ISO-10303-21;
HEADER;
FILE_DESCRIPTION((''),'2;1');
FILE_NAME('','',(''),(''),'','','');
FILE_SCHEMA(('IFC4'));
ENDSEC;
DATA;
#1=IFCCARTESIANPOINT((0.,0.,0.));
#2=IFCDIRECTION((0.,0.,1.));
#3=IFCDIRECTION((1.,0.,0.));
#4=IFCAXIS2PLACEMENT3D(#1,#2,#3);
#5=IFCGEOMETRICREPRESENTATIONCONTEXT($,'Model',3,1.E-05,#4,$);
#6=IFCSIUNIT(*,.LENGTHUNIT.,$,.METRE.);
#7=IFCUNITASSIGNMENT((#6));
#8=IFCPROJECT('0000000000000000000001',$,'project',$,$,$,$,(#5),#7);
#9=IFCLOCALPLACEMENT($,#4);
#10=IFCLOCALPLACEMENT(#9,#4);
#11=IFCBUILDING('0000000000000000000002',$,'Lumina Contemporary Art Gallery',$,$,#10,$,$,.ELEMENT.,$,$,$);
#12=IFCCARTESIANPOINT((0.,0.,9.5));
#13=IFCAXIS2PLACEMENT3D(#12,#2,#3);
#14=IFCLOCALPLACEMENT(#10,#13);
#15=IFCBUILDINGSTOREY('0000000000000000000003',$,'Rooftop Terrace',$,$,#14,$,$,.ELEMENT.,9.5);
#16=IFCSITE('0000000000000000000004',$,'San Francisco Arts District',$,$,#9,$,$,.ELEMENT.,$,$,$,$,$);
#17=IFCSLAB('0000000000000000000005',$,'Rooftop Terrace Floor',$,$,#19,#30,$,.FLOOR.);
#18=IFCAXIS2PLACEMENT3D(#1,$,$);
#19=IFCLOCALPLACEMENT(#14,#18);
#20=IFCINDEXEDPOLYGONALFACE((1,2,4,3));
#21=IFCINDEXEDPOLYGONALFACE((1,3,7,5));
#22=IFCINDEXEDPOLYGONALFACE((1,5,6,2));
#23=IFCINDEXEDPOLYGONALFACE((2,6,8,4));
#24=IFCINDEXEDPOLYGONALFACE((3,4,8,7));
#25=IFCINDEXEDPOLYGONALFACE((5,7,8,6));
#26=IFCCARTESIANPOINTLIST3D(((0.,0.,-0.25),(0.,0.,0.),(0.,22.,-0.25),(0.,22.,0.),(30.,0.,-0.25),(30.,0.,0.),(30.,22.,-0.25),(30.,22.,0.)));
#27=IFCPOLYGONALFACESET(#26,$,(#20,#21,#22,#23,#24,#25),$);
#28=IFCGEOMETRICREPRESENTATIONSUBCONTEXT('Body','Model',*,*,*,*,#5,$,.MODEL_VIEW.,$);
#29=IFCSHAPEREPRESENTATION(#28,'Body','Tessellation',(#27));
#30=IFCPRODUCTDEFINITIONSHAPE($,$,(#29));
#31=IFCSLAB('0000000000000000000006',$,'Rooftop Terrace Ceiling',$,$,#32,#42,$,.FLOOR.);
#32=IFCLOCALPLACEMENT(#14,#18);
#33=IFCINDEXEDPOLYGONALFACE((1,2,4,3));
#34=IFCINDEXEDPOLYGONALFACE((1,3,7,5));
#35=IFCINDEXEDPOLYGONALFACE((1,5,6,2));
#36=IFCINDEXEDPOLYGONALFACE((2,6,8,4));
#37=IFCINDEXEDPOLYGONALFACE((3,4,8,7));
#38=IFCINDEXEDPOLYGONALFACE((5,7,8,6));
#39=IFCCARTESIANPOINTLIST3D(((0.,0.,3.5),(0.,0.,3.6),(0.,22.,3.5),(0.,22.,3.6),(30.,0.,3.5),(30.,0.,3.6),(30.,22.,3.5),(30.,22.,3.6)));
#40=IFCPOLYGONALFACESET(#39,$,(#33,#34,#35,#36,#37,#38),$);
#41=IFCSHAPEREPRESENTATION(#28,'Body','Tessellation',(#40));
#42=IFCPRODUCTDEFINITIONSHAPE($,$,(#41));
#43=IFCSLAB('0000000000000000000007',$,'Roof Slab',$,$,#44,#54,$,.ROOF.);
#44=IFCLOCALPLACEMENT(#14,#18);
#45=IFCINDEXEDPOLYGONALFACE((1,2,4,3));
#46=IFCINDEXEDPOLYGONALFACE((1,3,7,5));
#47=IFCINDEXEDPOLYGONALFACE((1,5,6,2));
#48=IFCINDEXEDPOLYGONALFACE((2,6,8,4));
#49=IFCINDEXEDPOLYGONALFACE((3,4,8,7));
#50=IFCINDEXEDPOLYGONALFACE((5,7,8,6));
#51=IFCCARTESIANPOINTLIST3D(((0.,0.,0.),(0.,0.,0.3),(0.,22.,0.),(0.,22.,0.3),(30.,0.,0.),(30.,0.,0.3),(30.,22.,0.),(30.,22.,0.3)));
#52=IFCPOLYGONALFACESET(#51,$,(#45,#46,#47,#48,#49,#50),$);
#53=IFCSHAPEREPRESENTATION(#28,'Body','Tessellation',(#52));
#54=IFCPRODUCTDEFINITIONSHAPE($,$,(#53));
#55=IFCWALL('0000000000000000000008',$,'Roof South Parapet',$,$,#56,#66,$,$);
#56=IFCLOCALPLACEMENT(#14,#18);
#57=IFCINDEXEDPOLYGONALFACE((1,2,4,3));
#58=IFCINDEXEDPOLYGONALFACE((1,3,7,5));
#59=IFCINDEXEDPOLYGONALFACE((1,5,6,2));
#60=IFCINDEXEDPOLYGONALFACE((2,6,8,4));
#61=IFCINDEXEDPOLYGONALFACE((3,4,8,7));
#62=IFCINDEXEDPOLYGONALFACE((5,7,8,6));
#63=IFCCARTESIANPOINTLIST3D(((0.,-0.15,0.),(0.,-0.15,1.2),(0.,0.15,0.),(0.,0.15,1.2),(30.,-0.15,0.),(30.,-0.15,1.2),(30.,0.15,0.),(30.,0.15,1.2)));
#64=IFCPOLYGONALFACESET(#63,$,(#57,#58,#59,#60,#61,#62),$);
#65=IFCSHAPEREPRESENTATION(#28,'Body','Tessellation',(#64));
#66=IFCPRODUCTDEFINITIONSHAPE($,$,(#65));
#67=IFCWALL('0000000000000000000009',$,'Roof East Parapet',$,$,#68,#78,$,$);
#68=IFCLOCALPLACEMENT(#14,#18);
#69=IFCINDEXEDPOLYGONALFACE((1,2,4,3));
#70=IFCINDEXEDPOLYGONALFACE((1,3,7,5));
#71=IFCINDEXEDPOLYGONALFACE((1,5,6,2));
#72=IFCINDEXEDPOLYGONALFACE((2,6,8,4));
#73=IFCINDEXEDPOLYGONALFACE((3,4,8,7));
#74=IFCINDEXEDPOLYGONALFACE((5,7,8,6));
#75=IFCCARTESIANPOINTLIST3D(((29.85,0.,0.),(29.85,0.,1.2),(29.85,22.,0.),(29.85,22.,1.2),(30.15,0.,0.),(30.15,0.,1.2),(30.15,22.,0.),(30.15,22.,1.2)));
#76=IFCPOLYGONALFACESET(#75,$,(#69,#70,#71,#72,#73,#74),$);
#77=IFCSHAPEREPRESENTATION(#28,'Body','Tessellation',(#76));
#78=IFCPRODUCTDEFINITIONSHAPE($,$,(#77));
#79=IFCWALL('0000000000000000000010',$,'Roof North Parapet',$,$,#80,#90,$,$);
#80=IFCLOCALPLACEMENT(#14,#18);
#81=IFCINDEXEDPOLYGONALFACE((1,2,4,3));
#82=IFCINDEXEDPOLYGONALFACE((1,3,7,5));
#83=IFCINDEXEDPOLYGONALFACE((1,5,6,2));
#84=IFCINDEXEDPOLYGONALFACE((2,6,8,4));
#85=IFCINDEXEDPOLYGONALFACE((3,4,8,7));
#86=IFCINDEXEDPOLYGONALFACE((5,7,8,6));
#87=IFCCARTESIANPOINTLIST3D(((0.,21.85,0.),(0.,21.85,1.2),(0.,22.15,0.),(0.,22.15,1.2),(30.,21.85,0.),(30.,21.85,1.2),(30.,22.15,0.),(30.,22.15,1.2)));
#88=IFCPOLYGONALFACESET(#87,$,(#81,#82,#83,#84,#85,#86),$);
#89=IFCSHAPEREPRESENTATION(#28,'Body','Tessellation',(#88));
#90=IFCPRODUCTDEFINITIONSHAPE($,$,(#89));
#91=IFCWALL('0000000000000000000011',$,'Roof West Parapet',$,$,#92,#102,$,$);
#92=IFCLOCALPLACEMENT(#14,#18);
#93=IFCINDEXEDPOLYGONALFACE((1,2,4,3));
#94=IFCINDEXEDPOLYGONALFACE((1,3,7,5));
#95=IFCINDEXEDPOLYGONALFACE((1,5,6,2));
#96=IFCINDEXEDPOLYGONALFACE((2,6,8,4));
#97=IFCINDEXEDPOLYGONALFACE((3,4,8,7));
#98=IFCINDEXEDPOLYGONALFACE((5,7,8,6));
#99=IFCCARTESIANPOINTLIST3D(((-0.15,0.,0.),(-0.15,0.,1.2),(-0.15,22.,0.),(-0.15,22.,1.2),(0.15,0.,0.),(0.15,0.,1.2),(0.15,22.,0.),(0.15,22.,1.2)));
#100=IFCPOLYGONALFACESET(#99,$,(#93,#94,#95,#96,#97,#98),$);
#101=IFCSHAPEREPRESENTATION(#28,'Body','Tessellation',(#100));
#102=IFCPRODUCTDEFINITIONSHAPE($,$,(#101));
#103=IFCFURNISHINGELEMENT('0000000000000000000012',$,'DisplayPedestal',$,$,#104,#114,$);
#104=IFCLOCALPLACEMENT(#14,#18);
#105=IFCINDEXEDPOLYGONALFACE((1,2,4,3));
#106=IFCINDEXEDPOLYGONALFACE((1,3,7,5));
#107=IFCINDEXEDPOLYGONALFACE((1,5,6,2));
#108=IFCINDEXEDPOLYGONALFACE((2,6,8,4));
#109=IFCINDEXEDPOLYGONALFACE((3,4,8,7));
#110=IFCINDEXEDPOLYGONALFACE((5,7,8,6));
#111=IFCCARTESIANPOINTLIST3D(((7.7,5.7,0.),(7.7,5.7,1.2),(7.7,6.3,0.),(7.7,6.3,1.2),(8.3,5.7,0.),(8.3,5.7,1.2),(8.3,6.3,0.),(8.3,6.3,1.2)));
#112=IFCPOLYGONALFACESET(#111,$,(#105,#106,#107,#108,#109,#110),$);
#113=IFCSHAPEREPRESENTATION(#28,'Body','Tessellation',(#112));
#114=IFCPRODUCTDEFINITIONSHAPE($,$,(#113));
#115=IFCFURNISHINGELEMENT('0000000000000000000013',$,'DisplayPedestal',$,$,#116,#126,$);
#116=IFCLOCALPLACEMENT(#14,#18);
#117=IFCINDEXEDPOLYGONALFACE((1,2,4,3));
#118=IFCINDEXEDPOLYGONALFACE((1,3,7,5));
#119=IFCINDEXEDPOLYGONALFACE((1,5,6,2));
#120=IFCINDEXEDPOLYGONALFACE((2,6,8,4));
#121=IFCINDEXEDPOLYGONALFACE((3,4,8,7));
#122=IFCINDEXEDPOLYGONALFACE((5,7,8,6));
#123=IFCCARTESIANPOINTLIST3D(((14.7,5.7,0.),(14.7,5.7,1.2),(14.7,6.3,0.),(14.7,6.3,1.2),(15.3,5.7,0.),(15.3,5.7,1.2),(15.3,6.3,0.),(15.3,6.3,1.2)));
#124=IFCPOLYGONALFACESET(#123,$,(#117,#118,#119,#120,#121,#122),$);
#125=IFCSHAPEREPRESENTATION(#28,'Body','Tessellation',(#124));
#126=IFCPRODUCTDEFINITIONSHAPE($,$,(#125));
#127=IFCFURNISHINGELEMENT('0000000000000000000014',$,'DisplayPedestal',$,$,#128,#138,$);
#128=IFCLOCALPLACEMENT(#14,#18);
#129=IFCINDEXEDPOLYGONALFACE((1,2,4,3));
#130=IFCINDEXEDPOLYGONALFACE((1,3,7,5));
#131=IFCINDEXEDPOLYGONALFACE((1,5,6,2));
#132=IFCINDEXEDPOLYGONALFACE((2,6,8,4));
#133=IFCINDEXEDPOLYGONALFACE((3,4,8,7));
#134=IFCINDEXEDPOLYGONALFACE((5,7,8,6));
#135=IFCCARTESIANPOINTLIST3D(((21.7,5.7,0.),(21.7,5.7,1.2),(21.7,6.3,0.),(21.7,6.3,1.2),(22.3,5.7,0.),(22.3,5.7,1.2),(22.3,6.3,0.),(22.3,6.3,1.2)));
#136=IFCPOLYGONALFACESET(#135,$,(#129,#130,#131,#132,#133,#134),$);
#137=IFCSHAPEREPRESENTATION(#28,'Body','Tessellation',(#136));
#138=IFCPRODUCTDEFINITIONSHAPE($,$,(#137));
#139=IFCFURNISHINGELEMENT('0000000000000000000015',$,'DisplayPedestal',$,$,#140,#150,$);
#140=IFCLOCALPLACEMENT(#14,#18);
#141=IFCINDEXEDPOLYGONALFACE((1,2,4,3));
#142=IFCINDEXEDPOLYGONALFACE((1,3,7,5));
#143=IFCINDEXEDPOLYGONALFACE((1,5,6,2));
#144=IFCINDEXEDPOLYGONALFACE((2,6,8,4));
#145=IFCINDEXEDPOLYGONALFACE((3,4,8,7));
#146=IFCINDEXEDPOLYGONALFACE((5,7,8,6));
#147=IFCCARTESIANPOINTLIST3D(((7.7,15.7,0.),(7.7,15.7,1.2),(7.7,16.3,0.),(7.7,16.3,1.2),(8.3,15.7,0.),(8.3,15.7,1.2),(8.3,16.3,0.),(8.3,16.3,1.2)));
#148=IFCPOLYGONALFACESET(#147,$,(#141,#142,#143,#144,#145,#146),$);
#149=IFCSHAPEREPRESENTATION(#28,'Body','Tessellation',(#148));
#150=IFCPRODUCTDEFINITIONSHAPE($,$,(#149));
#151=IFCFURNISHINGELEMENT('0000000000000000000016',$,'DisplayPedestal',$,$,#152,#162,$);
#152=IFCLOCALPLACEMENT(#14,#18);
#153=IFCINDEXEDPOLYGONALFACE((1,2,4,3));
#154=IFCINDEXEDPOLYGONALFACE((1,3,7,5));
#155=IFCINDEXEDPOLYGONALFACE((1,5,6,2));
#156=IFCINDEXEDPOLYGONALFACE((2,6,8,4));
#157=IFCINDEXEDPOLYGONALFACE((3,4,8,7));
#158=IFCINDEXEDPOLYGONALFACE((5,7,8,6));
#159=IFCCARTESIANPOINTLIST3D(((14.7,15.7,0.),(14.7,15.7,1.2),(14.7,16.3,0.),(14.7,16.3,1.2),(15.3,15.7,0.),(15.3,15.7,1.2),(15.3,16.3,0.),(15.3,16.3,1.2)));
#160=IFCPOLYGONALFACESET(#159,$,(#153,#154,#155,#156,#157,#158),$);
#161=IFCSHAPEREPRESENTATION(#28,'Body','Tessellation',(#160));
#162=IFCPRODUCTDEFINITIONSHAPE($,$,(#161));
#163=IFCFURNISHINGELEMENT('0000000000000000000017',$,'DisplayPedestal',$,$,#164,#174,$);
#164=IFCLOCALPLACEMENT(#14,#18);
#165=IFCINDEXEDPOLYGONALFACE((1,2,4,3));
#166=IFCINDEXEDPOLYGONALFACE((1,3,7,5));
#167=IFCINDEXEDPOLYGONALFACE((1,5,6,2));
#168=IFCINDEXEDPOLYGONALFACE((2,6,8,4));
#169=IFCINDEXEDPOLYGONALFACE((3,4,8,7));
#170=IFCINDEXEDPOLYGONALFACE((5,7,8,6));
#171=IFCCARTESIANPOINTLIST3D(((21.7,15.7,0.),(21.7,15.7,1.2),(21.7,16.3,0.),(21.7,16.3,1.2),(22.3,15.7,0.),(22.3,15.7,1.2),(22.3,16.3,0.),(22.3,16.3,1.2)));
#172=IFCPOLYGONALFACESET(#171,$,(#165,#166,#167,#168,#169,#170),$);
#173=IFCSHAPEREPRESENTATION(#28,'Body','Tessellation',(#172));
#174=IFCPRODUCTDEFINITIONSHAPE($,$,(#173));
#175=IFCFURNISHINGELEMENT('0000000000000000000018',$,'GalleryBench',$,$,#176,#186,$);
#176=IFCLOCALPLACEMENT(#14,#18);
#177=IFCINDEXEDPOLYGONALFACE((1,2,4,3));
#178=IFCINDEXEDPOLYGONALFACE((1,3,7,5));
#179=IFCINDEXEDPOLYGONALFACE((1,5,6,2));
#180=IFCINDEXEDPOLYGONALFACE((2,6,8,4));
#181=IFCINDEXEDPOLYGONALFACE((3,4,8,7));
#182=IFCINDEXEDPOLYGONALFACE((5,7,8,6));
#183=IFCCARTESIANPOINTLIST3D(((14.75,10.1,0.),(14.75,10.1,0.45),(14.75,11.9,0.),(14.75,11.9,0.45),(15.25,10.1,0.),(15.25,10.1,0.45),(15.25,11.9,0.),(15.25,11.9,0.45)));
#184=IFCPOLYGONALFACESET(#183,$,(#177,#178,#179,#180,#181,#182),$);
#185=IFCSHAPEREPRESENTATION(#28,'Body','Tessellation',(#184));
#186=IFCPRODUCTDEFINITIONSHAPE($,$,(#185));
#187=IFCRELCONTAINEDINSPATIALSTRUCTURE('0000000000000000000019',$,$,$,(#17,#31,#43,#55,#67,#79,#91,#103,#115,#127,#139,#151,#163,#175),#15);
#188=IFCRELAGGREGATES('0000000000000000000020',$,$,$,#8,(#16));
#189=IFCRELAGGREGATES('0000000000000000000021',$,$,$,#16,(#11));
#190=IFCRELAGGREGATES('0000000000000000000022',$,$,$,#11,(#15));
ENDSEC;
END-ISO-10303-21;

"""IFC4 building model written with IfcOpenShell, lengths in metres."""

from ifc_helpers import new_model, si_unit, frame, origin_with_axes, place, context, subcontext, project, spatial, polyline, outline, extrude, element, save


model = new_model("IFC4")

# Units and contexts
model_context = context("Model", 3, precision=1e-05, world=origin_with_axes())
body_context = subcontext(model_context, "Body", "Model", "MODEL_VIEW")
ifc_project = project(units=[si_unit("LENGTHUNIT", "METRE")], contexts=[model_context])

# Site, building, storey
site_placement = place(None, origin_with_axes())
site = spatial("IfcSite", under=ifc_project, at=site_placement, Name="San Francisco Arts District", CompositionType="ELEMENT")
building_placement = place(site_placement, origin_with_axes())
building = spatial("IfcBuilding", under=site, at=building_placement, Name="Lumina Contemporary Art Gallery", CompositionType="ELEMENT")
storey_placement = place(building_placement, frame((0.0, 0.0, 9.5), z_axis=(0.0, 0.0, 1.0), x_axis=(1.0, 0.0, 0.0)))
storey = spatial("IfcBuildingStorey", under=building, at=storey_placement, Name="Rooftop Terrace", CompositionType="ELEMENT", Elevation=9.5)

# Slabs
slab_1_placement = place(storey_placement, origin_with_axes())
element("IfcSlab", 1, at=slab_1_placement, inside=storey, Name="Rooftop Terrace Floor", PredefinedType="FLOOR", context=body_context, shape_type="SweptSolid", body=[
    extrude(outline(polyline([(0.0, 0.0, -0.25), (30.0, 0.0, -0.25), (30.0, 22.0, -0.25), (0.0, 22.0, -0.25), (0.0, 0.0, -0.25)])), None, (0.0, 0.0, 1.0), 0.25),
])
slab_2_placement = place(storey_placement, origin_with_axes())
element("IfcSlab", 2, at=slab_2_placement, inside=storey, Name="Rooftop Terrace Ceiling", PredefinedType="FLOOR", context=body_context, shape_type="SweptSolid", body=[
    extrude(outline(polyline([(0.0, 0.0, 3.5), (30.0, 0.0, 3.5), (30.0, 22.0, 3.5), (0.0, 22.0, 3.5), (0.0, 0.0, 3.5)])), None, (0.0, 0.0, 1.0), 0.1),
])
slab_3_placement = place(storey_placement, origin_with_axes())
element("IfcSlab", 3, at=slab_3_placement, inside=storey, Name="Roof Slab", PredefinedType="ROOF", context=body_context, shape_type="SweptSolid", body=[
    extrude(outline(polyline([(0.0, 0.0, 0.0), (30.0, 0.0, 0.0), (30.0, 22.0, 0.0), (0.0, 22.0, 0.0), (0.0, 0.0, 0.0)])), None, (0.0, 0.0, 1.0), 0.3),
])

# Walls
wall_1_placement = place(storey_placement, origin_with_axes())
element("IfcWall", 4, at=wall_1_placement, inside=storey, Name="Roof South Parapet", context=body_context, shape_type="SweptSolid", body=[
    extrude(outline(polyline([(0.0, -0.15, 0.0), (30.0, -0.15, 0.0), (30.0, 0.15, 0.0), (0.0, 0.15, 0.0), (0.0, -0.15, 0.0)])), None, (0.0, 0.0, 1.0), 1.2),
])
wall_2_placement = place(storey_placement, origin_with_axes())
element("IfcWall", 5, at=wall_2_placement, inside=storey, Name="Roof East Parapet", context=body_context, shape_type="SweptSolid", body=[
    extrude(outline(polyline([(30.15, 0.0, 0.0), (30.15, 22.0, 0.0), (29.85, 22.0, 0.0), (29.85, 0.0, 0.0), (30.15, 0.0, 0.0)])), None, (0.0, 0.0, 1.0), 1.2),
])
wall_3_placement = place(storey_placement, origin_with_axes())
element("IfcWall", 6, at=wall_3_placement, inside=storey, Name="Roof North Parapet", context=body_context, shape_type="SweptSolid", body=[
    extrude(outline(polyline([(30.0, 22.15, 0.0), (0.0, 22.15, 0.0), (0.0, 21.85, 0.0), (30.0, 21.85, 0.0), (30.0, 22.15, 0.0)])), None, (0.0, 0.0, 1.0), 1.2),
])
wall_4_placement = place(storey_placement, origin_with_axes())
element("IfcWall", 7, at=wall_4_placement, inside=storey, Name="Roof West Parapet", context=body_context, shape_type="SweptSolid", body=[
    extrude(outline(polyline([(-0.15, 22.0, 0.0), (-0.15, 0.0, 0.0), (0.15, 0.0, 0.0), (0.15, 22.0, 0.0), (-0.15, 22.0, 0.0)])), None, (0.0, 0.0, 1.0), 1.2),
])

# Furnishing elements
furnishing_1_placement = place(storey_placement, origin_with_axes())
element("IfcFurnishingElement", 8, at=furnishing_1_placement, inside=storey, Name="DisplayPedestal", context=body_context, shape_type="SweptSolid", body=[
    extrude(outline(polyline([(8.3, 6.3, 0.0), (7.7, 6.3, 0.0), (7.7, 5.7, 0.0), (8.3, 5.7, 0.0), (8.3, 6.3, 0.0)])), None, (0.0, 0.0, 1.0), 1.2),
])
furnishing_2_placement = place(storey_placement, origin_with_axes())
element("IfcFurnishingElement", 9, at=furnishing_2_placement, inside=storey, Name="DisplayPedestal", context=body_context, shape_type="SweptSolid", body=[
    extrude(outline(polyline([(15.3, 6.3, 0.0), (14.7, 6.3, 0.0), (14.7, 5.7, 0.0), (15.3, 5.7, 0.0), (15.3, 6.3, 0.0)])), None, (0.0, 0.0, 1.0), 1.2),
])
furnishing_3_placement = place(storey_placement, origin_with_axes())
element("IfcFurnishingElement", 10, at=furnishing_3_placement, inside=storey, Name="DisplayPedestal", context=body_context, shape_type="SweptSolid", body=[
    extrude(outline(polyline([(22.3, 6.3, 0.0), (21.7, 6.3, 0.0), (21.7, 5.7, 0.0), (22.3, 5.7, 0.0), (22.3, 6.3, 0.0)])), None, (0.0, 0.0, 1.0), 1.2),
])
furnishing_4_placement = place(storey_placement, origin_with_axes())
element("IfcFurnishingElement", 11, at=furnishing_4_placement, inside=storey, Name="DisplayPedestal", context=body_context, shape_type="SweptSolid", body=[
    extrude(outline(polyline([(7.7, 15.7, 0.0), (8.3, 15.7, 0.0), (8.3, 16.3, 0.0), (7.7, 16.3, 0.0), (7.7, 15.7, 0.0)])), None, (0.0, 0.0, 1.0), 1.2),
])
furnishing_5_placement = place(storey_placement, origin_with_axes())
element("IfcFurnishingElement", 12, at=furnishing_5_placement, inside=storey, Name="DisplayPedestal", context=body_context, shape_type="SweptSolid", body=[
    extrude(outline(polyline([(14.7, 15.7, 0.0), (15.3, 15.7, 0.0), (15.3, 16.3, 0.0), (14.7, 16.3, 0.0), (14.7, 15.7, 0.0)])), None, (0.0, 0.0, 1.0), 1.2),
])
furnishing_6_placement = place(storey_placement, origin_with_axes())
element("IfcFurnishingElement", 13, at=furnishing_6_placement, inside=storey, Name="DisplayPedestal", context=body_context, shape_type="SweptSolid", body=[
    extrude(outline(polyline([(21.7, 15.7, 0.0), (22.3, 15.7, 0.0), (22.3, 16.3, 0.0), (21.7, 16.3, 0.0), (21.7, 15.7, 0.0)])), None, (0.0, 0.0, 1.0), 1.2),
])
furnishing_7_placement = place(storey_placement, origin_with_axes())
element("IfcFurnishingElement", 14, at=furnishing_7_placement, inside=storey, Name="GalleryBench", context=body_context, shape_type="SweptSolid", body=[
    extrude(outline(polyline([(14.75, 11.9, 0.0), (14.75, 10.1, 0.0), (15.25, 10.1, 0.0), (15.25, 11.9, 0.0), (14.75, 11.9, 0.0)])), None, (0.0, 0.0, 1.0), 0.45),
])

save(model, "model.ifc")
